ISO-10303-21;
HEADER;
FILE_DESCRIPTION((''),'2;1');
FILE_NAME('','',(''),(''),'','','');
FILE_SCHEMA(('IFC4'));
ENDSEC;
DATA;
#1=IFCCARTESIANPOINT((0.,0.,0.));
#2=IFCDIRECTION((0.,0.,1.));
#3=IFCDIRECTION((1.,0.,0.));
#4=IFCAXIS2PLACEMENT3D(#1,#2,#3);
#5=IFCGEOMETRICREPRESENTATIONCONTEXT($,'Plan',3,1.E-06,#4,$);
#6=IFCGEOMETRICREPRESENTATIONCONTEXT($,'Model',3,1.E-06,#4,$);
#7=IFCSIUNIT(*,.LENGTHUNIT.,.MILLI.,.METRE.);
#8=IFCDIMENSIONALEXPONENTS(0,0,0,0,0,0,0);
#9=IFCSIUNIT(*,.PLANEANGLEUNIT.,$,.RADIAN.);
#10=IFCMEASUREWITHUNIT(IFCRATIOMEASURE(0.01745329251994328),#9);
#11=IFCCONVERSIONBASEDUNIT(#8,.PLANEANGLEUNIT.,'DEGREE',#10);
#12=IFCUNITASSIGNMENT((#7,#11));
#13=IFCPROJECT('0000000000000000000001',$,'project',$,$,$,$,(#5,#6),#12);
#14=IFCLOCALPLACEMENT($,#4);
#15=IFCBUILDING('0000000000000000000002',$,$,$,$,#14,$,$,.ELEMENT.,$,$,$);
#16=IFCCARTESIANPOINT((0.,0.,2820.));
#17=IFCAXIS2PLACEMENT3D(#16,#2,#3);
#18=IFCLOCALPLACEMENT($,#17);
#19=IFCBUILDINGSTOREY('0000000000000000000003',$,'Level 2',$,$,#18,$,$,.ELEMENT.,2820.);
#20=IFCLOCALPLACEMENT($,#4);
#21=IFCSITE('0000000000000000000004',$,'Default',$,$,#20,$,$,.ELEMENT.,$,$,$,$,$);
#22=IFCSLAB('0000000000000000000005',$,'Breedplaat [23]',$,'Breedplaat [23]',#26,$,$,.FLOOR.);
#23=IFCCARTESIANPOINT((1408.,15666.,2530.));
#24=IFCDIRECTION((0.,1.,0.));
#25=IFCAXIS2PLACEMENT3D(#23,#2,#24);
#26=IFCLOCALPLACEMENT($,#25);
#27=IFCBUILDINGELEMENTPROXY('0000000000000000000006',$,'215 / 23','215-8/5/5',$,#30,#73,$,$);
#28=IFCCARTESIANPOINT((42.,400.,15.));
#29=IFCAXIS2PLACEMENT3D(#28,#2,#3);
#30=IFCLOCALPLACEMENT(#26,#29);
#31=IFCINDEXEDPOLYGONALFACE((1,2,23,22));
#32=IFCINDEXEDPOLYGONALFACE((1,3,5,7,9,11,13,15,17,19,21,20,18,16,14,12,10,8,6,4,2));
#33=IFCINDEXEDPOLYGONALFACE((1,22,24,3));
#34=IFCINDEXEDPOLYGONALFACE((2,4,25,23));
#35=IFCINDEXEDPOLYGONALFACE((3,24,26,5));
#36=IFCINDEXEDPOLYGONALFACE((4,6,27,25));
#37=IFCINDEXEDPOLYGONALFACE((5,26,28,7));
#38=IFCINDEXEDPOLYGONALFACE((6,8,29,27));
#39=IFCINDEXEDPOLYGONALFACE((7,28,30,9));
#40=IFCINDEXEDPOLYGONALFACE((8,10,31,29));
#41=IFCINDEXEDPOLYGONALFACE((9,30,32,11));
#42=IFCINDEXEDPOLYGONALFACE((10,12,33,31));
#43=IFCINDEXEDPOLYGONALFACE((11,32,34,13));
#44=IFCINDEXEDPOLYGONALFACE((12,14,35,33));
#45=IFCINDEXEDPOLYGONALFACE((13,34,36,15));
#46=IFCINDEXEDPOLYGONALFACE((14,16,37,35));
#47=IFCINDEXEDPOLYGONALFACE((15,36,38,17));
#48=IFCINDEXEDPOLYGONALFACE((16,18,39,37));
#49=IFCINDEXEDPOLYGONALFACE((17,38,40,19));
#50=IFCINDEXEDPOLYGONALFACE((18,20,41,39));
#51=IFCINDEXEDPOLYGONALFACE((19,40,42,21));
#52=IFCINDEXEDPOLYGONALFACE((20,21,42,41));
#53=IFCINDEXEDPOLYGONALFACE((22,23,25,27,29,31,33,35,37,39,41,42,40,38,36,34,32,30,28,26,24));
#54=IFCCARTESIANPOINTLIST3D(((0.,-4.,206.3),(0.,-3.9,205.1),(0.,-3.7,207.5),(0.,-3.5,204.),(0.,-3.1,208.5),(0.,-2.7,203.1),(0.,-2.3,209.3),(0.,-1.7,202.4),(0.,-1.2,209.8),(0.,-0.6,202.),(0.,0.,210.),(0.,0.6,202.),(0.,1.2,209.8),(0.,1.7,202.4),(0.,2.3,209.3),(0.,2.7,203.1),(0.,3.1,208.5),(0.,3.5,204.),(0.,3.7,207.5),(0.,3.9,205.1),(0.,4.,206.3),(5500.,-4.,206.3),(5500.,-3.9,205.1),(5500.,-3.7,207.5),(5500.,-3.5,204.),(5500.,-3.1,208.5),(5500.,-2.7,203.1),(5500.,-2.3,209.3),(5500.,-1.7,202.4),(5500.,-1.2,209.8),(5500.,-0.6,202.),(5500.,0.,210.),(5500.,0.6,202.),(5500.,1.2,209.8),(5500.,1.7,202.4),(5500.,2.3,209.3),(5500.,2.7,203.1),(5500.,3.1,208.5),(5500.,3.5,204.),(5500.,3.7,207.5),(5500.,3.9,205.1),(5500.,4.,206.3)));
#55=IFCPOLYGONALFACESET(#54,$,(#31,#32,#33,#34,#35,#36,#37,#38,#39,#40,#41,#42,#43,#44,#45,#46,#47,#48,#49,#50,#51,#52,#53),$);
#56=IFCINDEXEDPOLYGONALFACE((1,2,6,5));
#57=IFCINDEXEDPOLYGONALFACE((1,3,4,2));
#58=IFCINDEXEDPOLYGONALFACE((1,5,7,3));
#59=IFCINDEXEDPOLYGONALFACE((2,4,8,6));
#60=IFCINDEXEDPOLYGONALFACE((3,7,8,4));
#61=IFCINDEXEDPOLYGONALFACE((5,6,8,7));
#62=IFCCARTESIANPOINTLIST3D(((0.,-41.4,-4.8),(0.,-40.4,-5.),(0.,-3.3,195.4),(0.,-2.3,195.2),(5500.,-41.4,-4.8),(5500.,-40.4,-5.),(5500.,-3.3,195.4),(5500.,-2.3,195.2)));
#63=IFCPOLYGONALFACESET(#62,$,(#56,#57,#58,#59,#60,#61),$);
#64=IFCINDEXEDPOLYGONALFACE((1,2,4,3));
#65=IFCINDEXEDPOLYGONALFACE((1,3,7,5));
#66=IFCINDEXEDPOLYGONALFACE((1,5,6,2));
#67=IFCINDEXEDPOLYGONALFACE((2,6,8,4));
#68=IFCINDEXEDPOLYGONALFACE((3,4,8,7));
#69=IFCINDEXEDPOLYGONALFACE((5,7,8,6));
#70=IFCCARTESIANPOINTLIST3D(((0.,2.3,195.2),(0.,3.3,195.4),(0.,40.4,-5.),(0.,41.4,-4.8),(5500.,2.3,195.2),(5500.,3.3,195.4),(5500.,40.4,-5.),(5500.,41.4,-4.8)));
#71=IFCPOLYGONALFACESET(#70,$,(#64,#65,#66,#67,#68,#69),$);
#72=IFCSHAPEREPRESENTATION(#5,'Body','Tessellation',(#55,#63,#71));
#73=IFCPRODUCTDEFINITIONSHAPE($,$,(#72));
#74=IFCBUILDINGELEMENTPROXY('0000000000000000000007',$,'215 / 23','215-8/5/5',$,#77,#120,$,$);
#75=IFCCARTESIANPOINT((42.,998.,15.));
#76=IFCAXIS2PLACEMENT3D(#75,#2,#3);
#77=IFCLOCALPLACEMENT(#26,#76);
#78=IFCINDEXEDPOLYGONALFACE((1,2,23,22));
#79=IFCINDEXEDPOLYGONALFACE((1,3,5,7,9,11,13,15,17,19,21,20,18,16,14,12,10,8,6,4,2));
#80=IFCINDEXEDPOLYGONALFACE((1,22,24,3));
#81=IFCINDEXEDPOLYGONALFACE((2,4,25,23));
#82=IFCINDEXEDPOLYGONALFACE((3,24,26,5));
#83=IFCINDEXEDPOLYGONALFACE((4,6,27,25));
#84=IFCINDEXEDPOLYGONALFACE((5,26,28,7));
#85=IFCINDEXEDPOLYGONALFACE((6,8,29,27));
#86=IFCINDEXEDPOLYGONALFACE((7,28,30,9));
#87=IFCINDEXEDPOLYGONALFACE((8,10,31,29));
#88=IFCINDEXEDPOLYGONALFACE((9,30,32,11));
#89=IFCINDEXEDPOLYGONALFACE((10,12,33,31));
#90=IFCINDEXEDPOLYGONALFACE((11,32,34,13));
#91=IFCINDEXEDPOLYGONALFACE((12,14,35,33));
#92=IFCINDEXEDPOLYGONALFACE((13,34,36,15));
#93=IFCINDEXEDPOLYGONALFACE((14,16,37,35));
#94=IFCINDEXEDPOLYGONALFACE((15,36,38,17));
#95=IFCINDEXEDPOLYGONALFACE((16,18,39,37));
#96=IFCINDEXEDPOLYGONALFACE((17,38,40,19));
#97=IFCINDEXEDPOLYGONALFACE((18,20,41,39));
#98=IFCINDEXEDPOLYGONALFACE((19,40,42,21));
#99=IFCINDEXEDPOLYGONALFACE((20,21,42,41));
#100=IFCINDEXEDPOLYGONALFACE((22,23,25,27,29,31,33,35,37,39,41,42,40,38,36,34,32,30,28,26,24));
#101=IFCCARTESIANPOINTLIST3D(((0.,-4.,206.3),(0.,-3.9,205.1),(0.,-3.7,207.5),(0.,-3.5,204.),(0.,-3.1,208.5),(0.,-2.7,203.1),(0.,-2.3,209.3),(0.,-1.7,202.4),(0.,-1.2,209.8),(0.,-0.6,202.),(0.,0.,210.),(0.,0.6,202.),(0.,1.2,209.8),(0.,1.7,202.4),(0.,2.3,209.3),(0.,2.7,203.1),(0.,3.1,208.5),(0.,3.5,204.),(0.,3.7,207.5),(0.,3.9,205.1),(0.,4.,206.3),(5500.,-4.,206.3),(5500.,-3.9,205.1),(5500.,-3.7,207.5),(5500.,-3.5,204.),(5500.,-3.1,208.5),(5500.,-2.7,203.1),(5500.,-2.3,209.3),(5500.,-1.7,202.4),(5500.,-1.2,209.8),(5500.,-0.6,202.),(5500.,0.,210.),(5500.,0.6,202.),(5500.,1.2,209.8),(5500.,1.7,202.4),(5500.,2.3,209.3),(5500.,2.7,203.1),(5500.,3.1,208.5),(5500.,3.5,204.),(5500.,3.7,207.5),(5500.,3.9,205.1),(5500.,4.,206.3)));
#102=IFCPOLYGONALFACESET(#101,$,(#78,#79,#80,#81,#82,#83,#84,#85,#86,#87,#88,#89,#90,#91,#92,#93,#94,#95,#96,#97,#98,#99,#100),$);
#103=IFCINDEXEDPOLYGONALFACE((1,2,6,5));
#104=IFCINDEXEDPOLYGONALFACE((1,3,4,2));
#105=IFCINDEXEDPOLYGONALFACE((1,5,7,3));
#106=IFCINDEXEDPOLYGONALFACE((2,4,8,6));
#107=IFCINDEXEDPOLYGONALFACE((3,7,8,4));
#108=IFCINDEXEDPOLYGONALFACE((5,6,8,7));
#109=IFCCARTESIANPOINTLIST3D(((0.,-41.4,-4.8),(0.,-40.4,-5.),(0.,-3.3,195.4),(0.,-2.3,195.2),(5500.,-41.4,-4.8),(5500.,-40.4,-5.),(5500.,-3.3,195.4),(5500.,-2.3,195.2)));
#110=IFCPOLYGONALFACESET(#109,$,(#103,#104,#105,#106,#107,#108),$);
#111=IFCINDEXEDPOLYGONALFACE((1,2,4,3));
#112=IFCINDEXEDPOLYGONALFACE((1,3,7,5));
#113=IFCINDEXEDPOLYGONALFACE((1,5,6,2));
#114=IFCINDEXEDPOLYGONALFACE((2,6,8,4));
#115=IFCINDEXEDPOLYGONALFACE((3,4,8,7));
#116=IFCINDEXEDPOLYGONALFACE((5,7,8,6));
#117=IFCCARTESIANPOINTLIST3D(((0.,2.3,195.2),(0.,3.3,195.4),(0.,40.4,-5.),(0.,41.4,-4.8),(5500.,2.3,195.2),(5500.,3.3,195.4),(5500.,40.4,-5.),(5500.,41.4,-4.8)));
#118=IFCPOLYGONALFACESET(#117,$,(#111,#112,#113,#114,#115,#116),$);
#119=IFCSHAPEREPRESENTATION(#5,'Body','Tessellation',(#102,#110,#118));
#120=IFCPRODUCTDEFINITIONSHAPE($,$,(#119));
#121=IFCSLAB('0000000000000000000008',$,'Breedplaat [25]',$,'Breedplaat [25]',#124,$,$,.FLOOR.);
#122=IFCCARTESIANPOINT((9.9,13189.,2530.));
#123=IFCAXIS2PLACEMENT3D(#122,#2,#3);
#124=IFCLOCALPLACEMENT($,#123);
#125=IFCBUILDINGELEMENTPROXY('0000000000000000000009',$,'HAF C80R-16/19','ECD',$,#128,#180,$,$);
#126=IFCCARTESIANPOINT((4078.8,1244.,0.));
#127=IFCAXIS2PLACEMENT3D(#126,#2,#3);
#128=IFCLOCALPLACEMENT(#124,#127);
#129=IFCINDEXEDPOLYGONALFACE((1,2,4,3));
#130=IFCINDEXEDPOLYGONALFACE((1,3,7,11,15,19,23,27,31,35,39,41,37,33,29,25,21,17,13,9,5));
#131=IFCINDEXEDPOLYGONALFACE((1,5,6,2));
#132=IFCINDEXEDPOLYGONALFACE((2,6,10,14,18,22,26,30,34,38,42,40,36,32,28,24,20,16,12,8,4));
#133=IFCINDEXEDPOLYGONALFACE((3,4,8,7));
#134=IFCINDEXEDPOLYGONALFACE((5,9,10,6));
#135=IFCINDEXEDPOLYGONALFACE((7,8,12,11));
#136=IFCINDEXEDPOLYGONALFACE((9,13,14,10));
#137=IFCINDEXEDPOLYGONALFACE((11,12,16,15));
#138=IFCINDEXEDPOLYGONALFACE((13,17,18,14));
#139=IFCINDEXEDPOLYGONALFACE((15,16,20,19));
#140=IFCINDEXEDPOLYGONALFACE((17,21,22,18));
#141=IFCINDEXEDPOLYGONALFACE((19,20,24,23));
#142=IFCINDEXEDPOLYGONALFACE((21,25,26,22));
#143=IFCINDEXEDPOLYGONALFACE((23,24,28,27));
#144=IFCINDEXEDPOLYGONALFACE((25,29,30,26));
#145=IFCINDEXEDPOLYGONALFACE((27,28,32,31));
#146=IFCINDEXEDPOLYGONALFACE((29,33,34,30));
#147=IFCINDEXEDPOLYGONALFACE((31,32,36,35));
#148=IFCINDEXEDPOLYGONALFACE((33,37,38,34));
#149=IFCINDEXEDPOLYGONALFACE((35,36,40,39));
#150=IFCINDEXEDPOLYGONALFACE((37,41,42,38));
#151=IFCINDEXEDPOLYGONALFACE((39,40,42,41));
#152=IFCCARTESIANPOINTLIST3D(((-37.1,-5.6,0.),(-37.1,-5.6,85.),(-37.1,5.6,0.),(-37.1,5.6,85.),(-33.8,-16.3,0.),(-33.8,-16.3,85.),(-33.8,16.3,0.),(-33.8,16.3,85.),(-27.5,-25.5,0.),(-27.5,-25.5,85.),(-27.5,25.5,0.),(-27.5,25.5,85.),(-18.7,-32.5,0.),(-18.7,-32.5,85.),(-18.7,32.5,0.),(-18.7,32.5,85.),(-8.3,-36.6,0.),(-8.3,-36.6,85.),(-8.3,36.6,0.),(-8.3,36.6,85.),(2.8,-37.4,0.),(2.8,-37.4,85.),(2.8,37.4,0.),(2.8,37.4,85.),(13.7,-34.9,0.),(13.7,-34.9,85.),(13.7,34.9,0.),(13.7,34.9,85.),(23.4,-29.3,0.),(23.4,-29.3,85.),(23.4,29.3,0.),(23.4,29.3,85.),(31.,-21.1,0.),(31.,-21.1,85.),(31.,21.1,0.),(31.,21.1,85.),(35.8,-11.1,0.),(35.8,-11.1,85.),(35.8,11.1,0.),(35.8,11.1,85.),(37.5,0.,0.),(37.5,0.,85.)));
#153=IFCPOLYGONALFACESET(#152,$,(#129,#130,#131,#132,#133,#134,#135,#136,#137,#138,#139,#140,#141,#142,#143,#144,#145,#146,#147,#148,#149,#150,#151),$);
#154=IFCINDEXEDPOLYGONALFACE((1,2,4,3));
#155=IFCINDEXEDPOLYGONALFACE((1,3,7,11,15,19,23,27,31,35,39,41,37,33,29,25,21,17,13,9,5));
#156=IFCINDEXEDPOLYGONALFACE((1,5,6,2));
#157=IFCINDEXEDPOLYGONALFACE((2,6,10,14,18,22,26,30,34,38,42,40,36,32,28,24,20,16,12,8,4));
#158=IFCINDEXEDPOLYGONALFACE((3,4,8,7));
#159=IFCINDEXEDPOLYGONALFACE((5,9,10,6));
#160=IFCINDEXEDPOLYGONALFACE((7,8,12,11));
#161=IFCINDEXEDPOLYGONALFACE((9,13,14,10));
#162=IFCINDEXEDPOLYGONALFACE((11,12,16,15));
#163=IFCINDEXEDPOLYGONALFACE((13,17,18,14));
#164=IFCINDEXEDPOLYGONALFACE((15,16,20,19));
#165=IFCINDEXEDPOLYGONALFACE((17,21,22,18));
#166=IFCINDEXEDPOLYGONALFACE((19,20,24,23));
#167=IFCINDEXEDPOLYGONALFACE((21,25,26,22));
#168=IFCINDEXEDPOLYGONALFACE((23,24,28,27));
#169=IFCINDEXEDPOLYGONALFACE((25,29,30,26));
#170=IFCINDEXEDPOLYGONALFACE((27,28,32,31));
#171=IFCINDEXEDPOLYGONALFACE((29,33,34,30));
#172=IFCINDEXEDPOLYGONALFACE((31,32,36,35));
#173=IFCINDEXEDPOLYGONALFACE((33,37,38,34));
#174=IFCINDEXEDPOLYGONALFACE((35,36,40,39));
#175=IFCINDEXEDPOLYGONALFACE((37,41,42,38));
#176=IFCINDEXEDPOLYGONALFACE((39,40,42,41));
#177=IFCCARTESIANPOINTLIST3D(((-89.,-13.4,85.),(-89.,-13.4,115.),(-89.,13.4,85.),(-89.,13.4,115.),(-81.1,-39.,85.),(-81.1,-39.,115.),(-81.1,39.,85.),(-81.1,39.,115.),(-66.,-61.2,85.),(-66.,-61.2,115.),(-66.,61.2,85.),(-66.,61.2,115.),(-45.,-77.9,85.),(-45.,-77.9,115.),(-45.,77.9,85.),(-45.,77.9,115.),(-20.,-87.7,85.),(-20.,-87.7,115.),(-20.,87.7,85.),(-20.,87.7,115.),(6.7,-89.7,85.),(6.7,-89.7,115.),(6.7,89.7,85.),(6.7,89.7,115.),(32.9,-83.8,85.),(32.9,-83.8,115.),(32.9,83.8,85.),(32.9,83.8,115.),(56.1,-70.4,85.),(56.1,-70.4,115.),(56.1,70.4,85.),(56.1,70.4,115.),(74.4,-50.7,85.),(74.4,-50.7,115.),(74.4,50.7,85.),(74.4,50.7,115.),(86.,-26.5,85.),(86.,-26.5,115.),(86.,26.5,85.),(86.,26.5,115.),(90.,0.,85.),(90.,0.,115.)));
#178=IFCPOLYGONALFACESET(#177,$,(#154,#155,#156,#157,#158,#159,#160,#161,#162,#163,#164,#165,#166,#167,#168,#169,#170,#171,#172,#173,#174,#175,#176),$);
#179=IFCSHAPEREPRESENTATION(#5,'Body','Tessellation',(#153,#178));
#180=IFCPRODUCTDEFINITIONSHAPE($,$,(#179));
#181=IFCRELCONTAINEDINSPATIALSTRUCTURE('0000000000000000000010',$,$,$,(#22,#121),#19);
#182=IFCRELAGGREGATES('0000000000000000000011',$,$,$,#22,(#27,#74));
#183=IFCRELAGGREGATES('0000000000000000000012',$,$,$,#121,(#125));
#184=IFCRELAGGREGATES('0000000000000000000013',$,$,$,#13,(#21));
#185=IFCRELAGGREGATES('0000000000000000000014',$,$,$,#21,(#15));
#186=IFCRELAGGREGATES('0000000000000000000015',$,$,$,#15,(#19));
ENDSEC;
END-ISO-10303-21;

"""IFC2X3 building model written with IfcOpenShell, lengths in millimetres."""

from ifc_helpers import new_model, entity, si_unit, converted_unit, frame, origin_with_axes, origin_2d_with_axis, place, context, project, spatial, rectangle, circle, extrude, element, aggregate, save


model = new_model("IFC2X3")

# Units and contexts
plan_context = context("Plan", 3, precision=1e-06, world=origin_with_axes())
model_context = context("Model", 3, precision=1e-06, world=origin_with_axes())
ifc_project = project(units=[si_unit("LENGTHUNIT", "METRE", prefix="MILLI"), converted_unit("PLANEANGLEUNIT", "DEGREE", entity("IfcRatioMeasure", 0.01745329251994328), si_unit("PLANEANGLEUNIT", "RADIAN"), dimensions=[0, 0, 0, 0, 0, 0, 0])], contexts=[plan_context, model_context])

# Site, building, storey
site_placement = place(None, origin_with_axes())
site = spatial("IfcSite", under=ifc_project, at=site_placement, Name="Default", CompositionType="ELEMENT")
building_placement = place(None, origin_with_axes())
building = spatial("IfcBuilding", under=site, at=building_placement, CompositionType="ELEMENT")
storey_placement = place(None, frame((0.0, 0.0, 2820.0), z_axis=(0.0, 0.0, 1.0), x_axis=(1.0, 0.0, 0.0)))
storey = spatial("IfcBuildingStorey", under=building, at=storey_placement, Name="Level 2", CompositionType="ELEMENT", Elevation=2820.0)

# Slab, building element proxies
slab_1_placement = place(None, frame((1408.0, 15666.0, 2530.0), z_axis=(0.0, 0.0, 1.0), x_axis=(0.0, 1.0, 0.0)))
slab_1 = element("IfcSlab", 1, at=slab_1_placement, inside=storey, Name="Breedplaat [23]", ObjectType="Breedplaat [23]", PredefinedType="FLOOR")
proxy_1_placement = place(slab_1_placement, frame((42.0, 400.0, 15.0), z_axis=(0.0, 0.0, 1.0), x_axis=(1.0, 0.0, 0.0)))
proxy_1 = element("IfcBuildingElementProxy", 2, at=proxy_1_placement, Name="215 / 23", Description="215-8/5/5", context=plan_context, shape_type="SweptSolid", body=[
    extrude(circle(Radius=4.0, at=origin_2d_with_axis()), frame((0.0, 0.0, 206.0), z_axis=(1.0, 0.0, 0.0), x_axis=(0.0, 0.0, 1.0)), (0.0, 0.0, 1.0), 5500.0),
    extrude(rectangle(XDim=203.8, YDim=1.0, at=origin_2d_with_axis()), frame((0.0, -21.9, 95.2), z_axis=(1.0, 0.0, 0.0), x_axis=(0.0, 0.187112, 0.982339)), (0.0, 0.0, 1.0), 5500.0),
    extrude(rectangle(XDim=203.8, YDim=1.0, at=origin_2d_with_axis()), frame((0.0, 21.9, 95.2), z_axis=(1.0, 0.0, 0.0), x_axis=(0.0, -0.187112, 0.982339)), (0.0, 0.0, 1.0), 5500.0),
])
proxy_2_placement = place(slab_1_placement, frame((42.0, 998.0, 15.0), z_axis=(0.0, 0.0, 1.0), x_axis=(1.0, 0.0, 0.0)))
proxy_2 = element("IfcBuildingElementProxy", 3, at=proxy_2_placement, Name="215 / 23", Description="215-8/5/5", context=plan_context, shape_type="SweptSolid", body=[
    extrude(circle(Radius=4.0, at=origin_2d_with_axis()), frame((0.0, 0.0, 206.0), z_axis=(1.0, 0.0, 0.0), x_axis=(0.0, 0.0, 1.0)), (0.0, 0.0, 1.0), 5500.0),
    extrude(rectangle(XDim=203.8, YDim=1.0, at=origin_2d_with_axis()), frame((0.0, -21.9, 95.2), z_axis=(1.0, 0.0, 0.0), x_axis=(0.0, 0.187112, 0.982339)), (0.0, 0.0, 1.0), 5500.0),
    extrude(rectangle(XDim=203.8, YDim=1.0, at=origin_2d_with_axis()), frame((0.0, 21.9, 95.2), z_axis=(1.0, 0.0, 0.0), x_axis=(0.0, -0.187112, 0.982339)), (0.0, 0.0, 1.0), 5500.0),
])
aggregate(slab_1, [proxy_1, proxy_2])

# Slab, building element proxy
slab_2_placement = place(None, frame((9.9, 13189.0, 2530.0), z_axis=(0.0, 0.0, 1.0), x_axis=(1.0, 0.0, 0.0)))
slab_2 = element("IfcSlab", 4, at=slab_2_placement, inside=storey, Name="Breedplaat [25]", ObjectType="Breedplaat [25]", PredefinedType="FLOOR")
proxy_3_placement = place(slab_2_placement, frame((4078.8, 1244.0, 0.0), z_axis=(0.0, 0.0, 1.0), x_axis=(1.0, 0.0, 0.0)))
proxy_3 = element("IfcBuildingElementProxy", 5, at=proxy_3_placement, Name="HAF C80R-16/19", Description="ECD", context=plan_context, shape_type="SweptSolid", body=[
    extrude(circle(Radius=37.5, at=origin_2d_with_axis()), origin_with_axes(), (0.0, 0.0, 1.0), 85.0),
    extrude(circle(Radius=90.0, at=origin_2d_with_axis()), frame((0.0, 0.0, 85.0), z_axis=(0.0, 0.0, 1.0), x_axis=(1.0, 0.0, 0.0)), (0.0, 0.0, 1.0), 30.0),
])
aggregate(slab_2, [proxy_3])

save(model, "model.ifc")
